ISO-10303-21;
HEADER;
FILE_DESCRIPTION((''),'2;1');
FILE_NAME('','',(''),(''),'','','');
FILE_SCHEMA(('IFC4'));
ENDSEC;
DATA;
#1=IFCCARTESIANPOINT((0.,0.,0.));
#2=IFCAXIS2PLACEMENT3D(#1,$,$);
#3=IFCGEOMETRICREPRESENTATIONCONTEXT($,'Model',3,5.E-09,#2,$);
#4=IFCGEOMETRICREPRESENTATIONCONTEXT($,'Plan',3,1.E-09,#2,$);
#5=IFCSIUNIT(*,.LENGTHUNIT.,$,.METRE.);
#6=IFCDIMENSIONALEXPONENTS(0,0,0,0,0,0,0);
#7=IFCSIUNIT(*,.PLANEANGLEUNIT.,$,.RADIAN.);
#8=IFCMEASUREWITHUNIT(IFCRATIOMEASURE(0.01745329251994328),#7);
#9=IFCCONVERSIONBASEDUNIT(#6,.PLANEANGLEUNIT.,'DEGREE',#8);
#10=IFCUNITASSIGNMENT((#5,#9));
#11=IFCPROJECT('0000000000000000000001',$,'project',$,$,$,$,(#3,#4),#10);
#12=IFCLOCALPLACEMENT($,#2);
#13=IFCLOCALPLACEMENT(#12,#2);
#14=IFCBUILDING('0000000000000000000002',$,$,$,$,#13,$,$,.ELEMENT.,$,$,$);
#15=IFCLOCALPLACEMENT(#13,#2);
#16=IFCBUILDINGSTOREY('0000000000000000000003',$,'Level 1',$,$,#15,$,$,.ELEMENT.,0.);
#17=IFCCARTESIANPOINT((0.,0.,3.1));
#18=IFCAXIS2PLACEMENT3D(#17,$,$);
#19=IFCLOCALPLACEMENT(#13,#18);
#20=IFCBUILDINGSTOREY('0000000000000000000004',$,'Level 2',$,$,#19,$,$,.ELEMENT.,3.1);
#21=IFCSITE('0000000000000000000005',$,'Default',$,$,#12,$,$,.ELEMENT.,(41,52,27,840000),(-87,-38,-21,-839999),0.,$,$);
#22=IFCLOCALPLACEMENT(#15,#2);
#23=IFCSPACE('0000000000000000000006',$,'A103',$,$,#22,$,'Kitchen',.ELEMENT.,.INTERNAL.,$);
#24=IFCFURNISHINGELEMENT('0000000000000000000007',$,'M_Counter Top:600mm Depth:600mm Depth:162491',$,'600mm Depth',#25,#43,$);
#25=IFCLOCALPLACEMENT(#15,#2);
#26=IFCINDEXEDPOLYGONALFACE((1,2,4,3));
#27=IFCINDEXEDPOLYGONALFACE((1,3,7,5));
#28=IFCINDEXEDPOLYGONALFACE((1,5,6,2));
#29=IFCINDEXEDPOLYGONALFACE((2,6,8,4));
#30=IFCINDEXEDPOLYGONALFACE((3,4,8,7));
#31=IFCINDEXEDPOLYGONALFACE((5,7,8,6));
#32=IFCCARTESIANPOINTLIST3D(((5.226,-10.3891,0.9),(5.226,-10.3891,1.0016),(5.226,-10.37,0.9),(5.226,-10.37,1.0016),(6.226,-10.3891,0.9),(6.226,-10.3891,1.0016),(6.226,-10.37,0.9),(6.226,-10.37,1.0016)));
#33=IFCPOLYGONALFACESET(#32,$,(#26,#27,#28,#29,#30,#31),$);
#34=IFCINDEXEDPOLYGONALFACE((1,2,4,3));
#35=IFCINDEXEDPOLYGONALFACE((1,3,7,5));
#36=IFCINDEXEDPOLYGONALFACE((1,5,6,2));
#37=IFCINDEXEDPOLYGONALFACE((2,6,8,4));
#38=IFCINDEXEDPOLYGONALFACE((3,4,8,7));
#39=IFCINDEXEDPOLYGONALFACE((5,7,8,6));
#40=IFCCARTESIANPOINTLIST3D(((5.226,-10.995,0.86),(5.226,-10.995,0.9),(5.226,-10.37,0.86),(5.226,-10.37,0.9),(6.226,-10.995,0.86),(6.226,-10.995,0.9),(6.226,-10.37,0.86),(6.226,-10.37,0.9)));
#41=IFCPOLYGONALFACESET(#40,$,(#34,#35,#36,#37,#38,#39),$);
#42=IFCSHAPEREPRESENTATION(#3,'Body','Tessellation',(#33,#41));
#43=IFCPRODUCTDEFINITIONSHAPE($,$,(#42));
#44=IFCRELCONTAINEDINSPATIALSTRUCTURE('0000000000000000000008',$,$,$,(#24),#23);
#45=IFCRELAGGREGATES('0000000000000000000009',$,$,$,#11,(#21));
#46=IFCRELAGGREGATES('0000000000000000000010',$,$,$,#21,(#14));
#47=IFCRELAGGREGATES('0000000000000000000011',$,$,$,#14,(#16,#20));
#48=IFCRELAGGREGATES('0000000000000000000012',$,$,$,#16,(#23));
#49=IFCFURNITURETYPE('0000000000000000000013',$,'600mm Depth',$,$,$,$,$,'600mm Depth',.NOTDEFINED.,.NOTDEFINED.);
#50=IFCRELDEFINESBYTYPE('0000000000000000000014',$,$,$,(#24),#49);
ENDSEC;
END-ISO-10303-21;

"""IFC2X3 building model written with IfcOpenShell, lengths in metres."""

from ifc_helpers import new_model, entity, si_unit, converted_unit, frame, origin, origin_2d_with_axis, place, context, project, spatial, rectangle, extrude, source, transform, mapped, type_object, type_shapes, element, save


model = new_model("IFC2X3")

# Units and contexts
model_context = context("Model", 3, precision=5e-09, world=origin())
plan_context = context("Plan", 3, precision=1e-09, world=origin())
ifc_project = project(units=[si_unit("LENGTHUNIT", "METRE"), converted_unit("PLANEANGLEUNIT", "DEGREE", entity("IfcRatioMeasure", 0.01745329251994328), si_unit("PLANEANGLEUNIT", "RADIAN"), dimensions=[0, 0, 0, 0, 0, 0, 0])], contexts=[model_context, plan_context])

# Site, building, storey
site_placement = place(None, origin())
site = spatial("IfcSite", under=ifc_project, at=site_placement, Name="Default", CompositionType="ELEMENT", RefLatitude=(41, 52, 27, 840000), RefLongitude=(-87, -38, -21, -839999), RefElevation=0.0)
building_placement = place(site_placement, origin())
building = spatial("IfcBuilding", under=site, at=building_placement, CompositionType="ELEMENT")
storey_1_placement = place(building_placement, origin())
storey_1 = spatial("IfcBuildingStorey", under=building, at=storey_1_placement, Name="Level 1", CompositionType="ELEMENT", Elevation=0.0)

# Shared definitions
storey_2_placement = place(building_placement, frame((0.0, 0.0, 3.1)))
storey_2 = spatial("IfcBuildingStorey", under=building, at=storey_2_placement, Name="Level 2", CompositionType="ELEMENT", Elevation=3.1)

# Shared definitions
space_1_placement = place(storey_1_placement, origin())
space_1 = spatial("IfcSpace", under=storey_1, at=space_1_placement, Name="A103", LongName="Kitchen", CompositionType="ELEMENT", InteriorOrExteriorSpace="INTERNAL")

# Furnishing element
furniture_type_1 = type_object("IfcFurnitureType", Name="600mm Depth", ElementType="600mm Depth", AssemblyPlace="NOTDEFINED")
shared_shape_1 = source(origin(), model_context, "Body", "SweptSolid", [
    extrude(rectangle(XDim=0.0191, YDim=1.0, at=origin_2d_with_axis()), frame((-0.7005, -0.0095, 0.9), z_axis=(0.0, 0.0, 1.0), x_axis=(0.0, -1.0, 0.0)), (0.0, 0.0, 1.0), 0.1016),
    extrude(rectangle(XDim=1.0, YDim=0.625, at=origin_2d_with_axis()), frame((-0.7005, -0.3125, 0.86), z_axis=(0.0, 0.0, 1.0), x_axis=(-1.0, 0.0, 0.0)), (0.0, 0.0, 1.0), 0.04),
])
type_shapes(furniture_type_1, [shared_shape_1])
furnishing_1_placement = place(space_1_placement, frame((6.4265, -10.37, 0.0)))
element("IfcFurnishingElement", 1, at=furnishing_1_placement, inside=space_1, type_object=furniture_type_1, Name="M_Counter Top:600mm Depth:600mm Depth:162491", ObjectType="600mm Depth", context=model_context, shape_type="MappedRepresentation", body=[
    mapped(shared_shape_1, transform((0.0, 0.0, 0.0), scale=1.0)),
])

save(model, "model.ifc")
